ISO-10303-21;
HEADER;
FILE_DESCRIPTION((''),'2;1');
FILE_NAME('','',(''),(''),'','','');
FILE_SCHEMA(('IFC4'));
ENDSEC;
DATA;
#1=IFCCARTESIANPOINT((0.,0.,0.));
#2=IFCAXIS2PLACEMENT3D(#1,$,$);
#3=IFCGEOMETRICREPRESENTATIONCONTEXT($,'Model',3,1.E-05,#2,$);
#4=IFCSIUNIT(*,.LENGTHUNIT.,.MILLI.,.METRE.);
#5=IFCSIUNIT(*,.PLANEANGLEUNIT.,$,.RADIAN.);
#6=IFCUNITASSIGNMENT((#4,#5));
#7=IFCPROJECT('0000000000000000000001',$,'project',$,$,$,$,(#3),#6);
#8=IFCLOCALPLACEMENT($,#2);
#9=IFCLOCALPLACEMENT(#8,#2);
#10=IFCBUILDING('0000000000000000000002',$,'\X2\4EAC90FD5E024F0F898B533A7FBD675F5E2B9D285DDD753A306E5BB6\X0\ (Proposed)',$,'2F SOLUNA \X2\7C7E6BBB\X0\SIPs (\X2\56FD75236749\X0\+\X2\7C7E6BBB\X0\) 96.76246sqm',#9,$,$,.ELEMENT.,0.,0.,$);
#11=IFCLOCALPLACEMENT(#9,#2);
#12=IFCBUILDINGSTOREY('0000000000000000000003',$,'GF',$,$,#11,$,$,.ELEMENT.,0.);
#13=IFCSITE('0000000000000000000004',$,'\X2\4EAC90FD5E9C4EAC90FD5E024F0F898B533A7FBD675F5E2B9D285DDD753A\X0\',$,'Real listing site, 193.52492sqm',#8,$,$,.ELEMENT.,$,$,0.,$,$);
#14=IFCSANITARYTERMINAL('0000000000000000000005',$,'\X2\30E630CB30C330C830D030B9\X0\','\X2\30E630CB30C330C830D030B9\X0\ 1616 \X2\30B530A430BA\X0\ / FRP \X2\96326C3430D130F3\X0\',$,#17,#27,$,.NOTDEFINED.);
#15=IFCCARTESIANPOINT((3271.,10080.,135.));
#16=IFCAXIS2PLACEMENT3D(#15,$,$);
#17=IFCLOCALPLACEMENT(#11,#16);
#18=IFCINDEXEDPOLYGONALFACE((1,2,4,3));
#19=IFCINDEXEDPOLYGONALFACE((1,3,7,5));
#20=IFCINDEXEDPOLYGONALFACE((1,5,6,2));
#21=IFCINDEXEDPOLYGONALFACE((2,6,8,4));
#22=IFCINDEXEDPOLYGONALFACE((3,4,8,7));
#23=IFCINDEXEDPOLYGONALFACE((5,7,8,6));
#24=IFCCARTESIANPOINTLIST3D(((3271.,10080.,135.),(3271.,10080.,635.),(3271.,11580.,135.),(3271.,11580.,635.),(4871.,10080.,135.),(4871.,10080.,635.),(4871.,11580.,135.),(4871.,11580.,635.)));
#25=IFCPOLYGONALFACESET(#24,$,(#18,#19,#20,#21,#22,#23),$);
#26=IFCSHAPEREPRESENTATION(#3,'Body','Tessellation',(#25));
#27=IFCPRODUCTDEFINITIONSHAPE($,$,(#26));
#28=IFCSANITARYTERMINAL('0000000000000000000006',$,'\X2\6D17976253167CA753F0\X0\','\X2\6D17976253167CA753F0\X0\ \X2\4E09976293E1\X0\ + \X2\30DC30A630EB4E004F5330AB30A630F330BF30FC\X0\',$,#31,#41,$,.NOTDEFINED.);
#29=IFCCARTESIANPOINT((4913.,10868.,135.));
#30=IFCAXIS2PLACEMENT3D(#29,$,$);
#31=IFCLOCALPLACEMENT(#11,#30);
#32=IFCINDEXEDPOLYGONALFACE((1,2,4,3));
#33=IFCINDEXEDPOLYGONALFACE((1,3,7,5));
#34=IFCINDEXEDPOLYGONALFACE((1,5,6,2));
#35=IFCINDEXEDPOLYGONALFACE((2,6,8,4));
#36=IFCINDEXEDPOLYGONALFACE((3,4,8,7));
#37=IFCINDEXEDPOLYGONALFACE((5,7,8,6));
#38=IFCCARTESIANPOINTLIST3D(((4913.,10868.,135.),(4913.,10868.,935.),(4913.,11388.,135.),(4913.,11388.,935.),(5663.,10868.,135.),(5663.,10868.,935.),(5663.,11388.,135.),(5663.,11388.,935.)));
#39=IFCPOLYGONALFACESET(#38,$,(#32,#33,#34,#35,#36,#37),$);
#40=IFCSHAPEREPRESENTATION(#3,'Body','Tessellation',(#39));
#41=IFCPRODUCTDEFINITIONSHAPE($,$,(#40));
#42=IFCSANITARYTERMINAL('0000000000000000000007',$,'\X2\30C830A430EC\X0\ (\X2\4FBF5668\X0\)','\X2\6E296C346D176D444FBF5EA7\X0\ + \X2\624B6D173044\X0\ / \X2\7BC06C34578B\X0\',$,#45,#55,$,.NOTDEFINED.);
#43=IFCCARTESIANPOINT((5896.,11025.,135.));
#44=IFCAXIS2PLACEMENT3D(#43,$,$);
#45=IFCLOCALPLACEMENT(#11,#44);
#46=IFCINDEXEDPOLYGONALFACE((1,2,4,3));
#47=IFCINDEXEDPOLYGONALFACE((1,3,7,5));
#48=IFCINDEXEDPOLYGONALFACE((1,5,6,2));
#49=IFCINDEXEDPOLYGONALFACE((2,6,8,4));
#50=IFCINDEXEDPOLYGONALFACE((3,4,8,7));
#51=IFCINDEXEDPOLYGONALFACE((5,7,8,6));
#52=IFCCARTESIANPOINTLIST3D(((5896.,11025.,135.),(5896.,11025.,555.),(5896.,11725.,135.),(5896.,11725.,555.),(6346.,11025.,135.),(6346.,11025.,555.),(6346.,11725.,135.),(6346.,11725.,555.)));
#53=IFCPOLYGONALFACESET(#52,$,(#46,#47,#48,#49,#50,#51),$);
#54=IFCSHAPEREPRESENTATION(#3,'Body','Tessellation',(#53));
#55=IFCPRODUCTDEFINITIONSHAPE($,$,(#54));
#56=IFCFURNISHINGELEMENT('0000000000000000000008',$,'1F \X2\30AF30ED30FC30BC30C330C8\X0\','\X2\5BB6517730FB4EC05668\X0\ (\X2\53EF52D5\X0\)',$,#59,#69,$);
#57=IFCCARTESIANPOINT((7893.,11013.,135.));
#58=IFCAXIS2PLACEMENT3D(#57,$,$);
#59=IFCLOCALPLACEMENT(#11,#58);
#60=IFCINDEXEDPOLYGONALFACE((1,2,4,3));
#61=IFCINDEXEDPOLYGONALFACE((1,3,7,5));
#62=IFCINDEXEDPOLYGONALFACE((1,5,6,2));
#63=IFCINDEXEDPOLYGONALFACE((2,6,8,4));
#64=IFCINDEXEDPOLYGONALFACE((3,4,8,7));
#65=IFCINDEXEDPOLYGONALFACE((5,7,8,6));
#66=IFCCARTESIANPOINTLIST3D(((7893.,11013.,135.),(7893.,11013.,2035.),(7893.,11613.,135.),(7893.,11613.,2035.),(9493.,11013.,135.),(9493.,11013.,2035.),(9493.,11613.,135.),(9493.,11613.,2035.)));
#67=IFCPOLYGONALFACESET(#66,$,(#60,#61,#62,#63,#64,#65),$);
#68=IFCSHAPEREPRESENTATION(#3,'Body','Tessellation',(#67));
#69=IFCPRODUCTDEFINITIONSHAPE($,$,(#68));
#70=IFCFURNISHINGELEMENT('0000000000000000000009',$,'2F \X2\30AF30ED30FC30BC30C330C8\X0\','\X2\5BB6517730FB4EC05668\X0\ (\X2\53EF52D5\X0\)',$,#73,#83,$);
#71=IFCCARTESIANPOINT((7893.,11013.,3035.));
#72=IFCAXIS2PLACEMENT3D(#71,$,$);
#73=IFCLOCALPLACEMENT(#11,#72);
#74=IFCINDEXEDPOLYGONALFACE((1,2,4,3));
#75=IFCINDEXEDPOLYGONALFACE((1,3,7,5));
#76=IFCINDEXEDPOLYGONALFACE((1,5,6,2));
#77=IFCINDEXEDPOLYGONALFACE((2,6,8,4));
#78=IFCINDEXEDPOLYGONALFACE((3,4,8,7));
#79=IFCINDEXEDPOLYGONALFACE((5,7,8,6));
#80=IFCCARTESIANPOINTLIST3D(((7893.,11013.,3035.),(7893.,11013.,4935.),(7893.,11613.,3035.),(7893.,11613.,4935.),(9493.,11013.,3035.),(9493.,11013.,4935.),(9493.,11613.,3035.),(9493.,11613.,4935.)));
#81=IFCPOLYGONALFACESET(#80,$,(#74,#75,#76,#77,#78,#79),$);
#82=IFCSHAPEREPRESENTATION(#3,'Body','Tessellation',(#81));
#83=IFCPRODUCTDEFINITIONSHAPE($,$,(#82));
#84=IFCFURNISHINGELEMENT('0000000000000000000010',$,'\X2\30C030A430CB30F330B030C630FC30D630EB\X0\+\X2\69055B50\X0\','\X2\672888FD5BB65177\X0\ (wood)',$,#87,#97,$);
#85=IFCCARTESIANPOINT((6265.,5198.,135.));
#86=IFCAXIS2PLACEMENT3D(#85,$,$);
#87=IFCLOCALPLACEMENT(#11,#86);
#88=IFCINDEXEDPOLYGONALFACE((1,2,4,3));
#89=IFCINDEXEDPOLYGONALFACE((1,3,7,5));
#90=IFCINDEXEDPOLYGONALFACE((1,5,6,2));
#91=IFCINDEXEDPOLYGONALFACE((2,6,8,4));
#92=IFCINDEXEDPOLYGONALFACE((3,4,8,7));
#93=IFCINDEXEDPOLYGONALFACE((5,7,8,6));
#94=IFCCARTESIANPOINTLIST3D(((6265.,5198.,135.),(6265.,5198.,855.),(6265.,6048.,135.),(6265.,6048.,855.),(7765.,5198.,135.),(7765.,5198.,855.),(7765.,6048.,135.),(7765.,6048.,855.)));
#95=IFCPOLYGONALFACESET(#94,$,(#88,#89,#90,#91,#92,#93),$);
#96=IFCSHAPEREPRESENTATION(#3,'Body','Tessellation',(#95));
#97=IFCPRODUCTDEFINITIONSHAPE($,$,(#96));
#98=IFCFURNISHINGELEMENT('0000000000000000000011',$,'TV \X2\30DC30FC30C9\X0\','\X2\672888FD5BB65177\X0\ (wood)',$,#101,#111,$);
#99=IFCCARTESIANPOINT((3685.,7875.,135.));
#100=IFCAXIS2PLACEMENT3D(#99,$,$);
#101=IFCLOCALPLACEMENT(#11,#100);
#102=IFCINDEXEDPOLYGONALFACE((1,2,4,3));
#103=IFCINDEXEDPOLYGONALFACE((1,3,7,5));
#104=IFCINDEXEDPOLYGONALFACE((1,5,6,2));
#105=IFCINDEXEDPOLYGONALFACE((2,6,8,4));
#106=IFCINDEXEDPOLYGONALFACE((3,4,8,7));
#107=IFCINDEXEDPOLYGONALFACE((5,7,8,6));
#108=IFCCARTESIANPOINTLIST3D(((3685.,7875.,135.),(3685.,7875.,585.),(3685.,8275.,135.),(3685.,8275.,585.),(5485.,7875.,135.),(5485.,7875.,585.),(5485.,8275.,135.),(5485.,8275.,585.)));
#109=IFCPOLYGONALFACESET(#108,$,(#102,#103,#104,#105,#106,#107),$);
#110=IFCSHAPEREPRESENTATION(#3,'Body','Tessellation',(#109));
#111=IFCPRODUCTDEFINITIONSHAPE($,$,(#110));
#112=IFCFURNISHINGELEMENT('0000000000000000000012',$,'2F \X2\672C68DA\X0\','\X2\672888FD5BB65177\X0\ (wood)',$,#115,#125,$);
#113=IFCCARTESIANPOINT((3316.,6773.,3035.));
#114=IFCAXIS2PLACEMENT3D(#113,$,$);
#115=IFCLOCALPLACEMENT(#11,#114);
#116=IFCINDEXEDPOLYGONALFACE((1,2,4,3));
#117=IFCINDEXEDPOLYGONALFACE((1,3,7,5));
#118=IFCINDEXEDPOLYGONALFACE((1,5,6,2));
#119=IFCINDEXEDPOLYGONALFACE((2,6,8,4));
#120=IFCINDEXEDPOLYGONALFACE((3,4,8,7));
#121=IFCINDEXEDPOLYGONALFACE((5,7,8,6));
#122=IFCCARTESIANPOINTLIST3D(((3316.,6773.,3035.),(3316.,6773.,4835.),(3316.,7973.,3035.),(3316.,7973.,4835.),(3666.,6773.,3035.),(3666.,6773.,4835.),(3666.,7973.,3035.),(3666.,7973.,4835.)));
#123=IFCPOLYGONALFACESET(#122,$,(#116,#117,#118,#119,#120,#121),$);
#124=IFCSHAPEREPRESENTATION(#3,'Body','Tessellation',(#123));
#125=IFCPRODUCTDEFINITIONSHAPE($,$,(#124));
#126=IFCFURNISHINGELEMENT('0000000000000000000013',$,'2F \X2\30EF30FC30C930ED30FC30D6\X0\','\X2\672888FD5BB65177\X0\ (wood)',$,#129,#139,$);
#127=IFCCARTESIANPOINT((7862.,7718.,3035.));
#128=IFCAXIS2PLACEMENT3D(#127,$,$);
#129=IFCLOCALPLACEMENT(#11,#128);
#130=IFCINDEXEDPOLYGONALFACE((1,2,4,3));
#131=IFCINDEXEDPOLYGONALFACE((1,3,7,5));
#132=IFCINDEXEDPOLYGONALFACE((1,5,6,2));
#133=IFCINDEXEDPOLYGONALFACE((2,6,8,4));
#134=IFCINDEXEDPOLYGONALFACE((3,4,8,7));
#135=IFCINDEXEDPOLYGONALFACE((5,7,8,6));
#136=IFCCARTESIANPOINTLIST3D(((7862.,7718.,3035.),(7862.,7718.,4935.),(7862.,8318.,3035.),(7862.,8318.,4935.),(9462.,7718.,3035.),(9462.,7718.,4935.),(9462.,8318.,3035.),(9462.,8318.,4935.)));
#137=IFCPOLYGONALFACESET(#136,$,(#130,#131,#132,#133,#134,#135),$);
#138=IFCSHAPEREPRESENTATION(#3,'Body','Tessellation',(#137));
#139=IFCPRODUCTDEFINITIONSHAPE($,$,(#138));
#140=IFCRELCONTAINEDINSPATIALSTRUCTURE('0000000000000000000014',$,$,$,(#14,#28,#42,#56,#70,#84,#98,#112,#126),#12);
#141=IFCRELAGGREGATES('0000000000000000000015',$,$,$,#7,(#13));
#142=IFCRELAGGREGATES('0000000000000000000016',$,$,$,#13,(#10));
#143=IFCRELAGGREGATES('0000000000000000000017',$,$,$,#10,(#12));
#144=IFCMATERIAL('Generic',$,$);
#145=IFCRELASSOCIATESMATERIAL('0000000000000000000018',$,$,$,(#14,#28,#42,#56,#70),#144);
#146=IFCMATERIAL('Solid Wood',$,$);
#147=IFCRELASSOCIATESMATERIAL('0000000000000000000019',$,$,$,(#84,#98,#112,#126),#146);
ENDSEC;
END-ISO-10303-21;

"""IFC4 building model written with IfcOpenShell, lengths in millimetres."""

from ifc_helpers import new_model, si_unit, frame, frame_2d, origin, place, context, project, spatial, rectangle, extrude, material, element, save


model = new_model("IFC4")

# Units and contexts
model_context = context("Model", 3, precision=1e-05, world=origin())
ifc_project = project(units=[si_unit("LENGTHUNIT", "METRE", prefix="MILLI"), si_unit("PLANEANGLEUNIT", "RADIAN")], contexts=[model_context])

# Site, building, storey
site_placement = place(None, origin())
site = spatial("IfcSite", under=ifc_project, at=site_placement, Name="京都府京都市伏見区羽束師鴨川町", ObjectType="Real listing site, 193.52492sqm", CompositionType="ELEMENT", RefElevation=0.0)
building_placement = place(site_placement, origin())
building = spatial("IfcBuilding", under=site, at=building_placement, Name="京都市伏見区羽束師鴨川町の家 (Proposed)", ObjectType="2F SOLUNA 籾殻SIPs (国産杉+籾殻) 96.76246sqm", CompositionType="ELEMENT", ElevationOfRefHeight=0.0, ElevationOfTerrain=0.0)
storey_placement = place(building_placement, origin())
storey = spatial("IfcBuildingStorey", under=building, at=storey_placement, Name="GF", CompositionType="ELEMENT", Elevation=0.0)

# Shared definitions
ifc_material_1 = material(Name="Solid Wood")

# Sanitary terminals
ifc_material_2 = material(Name="Generic")
sanitary_terminal_1_placement = place(storey_placement, frame((3271.0, 10080.0, 135.0)))
element("IfcSanitaryTerminal", 1, at=sanitary_terminal_1_placement, inside=storey, material=ifc_material_2, Name="ユニットバス", Description="ユニットバス 1616 サイズ / FRP 防水パン", PredefinedType="NOTDEFINED", context=model_context, shape_type="SweptSolid", body=[
    extrude(rectangle(XDim=1600.0, YDim=1500.0, at=frame_2d((800.0, 750.0))), frame((3271.0, 10080.0, 135.0)), (0.0, 0.0, 1.0), 500.0),
])
sanitary_terminal_2_placement = place(storey_placement, frame((4913.0, 10868.0, 135.0)))
element("IfcSanitaryTerminal", 2, at=sanitary_terminal_2_placement, inside=storey, material=ifc_material_2, Name="洗面化粧台", Description="洗面化粧台 三面鏡 + ボウル一体カウンター", PredefinedType="NOTDEFINED", context=model_context, shape_type="SweptSolid", body=[
    extrude(rectangle(XDim=750.0, YDim=520.0, at=frame_2d((375.0, 260.0))), frame((4913.0, 10868.0, 135.0)), (0.0, 0.0, 1.0), 800.0),
])
sanitary_terminal_3_placement = place(storey_placement, frame((5896.0, 11025.0, 135.0)))
element("IfcSanitaryTerminal", 3, at=sanitary_terminal_3_placement, inside=storey, material=ifc_material_2, Name="トイレ (便器)", Description="温水洗浄便座 + 手洗い / 節水型", PredefinedType="NOTDEFINED", context=model_context, shape_type="SweptSolid", body=[
    extrude(rectangle(XDim=450.0, YDim=700.0, at=frame_2d((225.0, 350.0))), frame((5896.0, 11025.0, 135.0)), (0.0, 0.0, 1.0), 420.0),
])

# Furnishing elements
furnishing_1_placement = place(storey_placement, frame((7893.0, 11013.0, 135.0)))
element("IfcFurnishingElement", 4, at=furnishing_1_placement, inside=storey, material=ifc_material_2, Name="1F クローゼット", Description="家具・什器 (可動)", context=model_context, shape_type="SweptSolid", body=[
    extrude(rectangle(XDim=1600.0, YDim=600.0, at=frame_2d((800.0, 300.0))), frame((7893.0, 11013.0, 135.0)), (0.0, 0.0, 1.0), 1900.0),
])
furnishing_2_placement = place(storey_placement, frame((7893.0, 11013.0, 3035.0)))
element("IfcFurnishingElement", 5, at=furnishing_2_placement, inside=storey, material=ifc_material_2, Name="2F クローゼット", Description="家具・什器 (可動)", context=model_context, shape_type="SweptSolid", body=[
    extrude(rectangle(XDim=1600.0, YDim=600.0, at=frame_2d((800.0, 300.0))), frame((7893.0, 11013.0, 3035.0)), (0.0, 0.0, 1.0), 1900.0),
])
furnishing_3_placement = place(storey_placement, frame((6265.0, 5198.0, 135.0)))
element("IfcFurnishingElement", 6, at=furnishing_3_placement, inside=storey, material=ifc_material_1, Name="ダイニングテーブル+椅子", Description="木製家具 (wood)", context=model_context, shape_type="SweptSolid", body=[
    extrude(rectangle(XDim=1500.0, YDim=850.0, at=frame_2d((750.0, 425.0))), frame((6265.0, 5198.0, 135.0)), (0.0, 0.0, 1.0), 720.0),
])
furnishing_4_placement = place(storey_placement, frame((3685.0, 7875.0, 135.0)))
element("IfcFurnishingElement", 7, at=furnishing_4_placement, inside=storey, material=ifc_material_1, Name="TV ボード", Description="木製家具 (wood)", context=model_context, shape_type="SweptSolid", body=[
    extrude(rectangle(XDim=1800.0, YDim=400.0, at=frame_2d((900.0, 200.0))), frame((3685.0, 7875.0, 135.0)), (0.0, 0.0, 1.0), 450.0),
])
furnishing_5_placement = place(storey_placement, frame((3316.0, 6773.0, 3035.0)))
element("IfcFurnishingElement", 8, at=furnishing_5_placement, inside=storey, material=ifc_material_1, Name="2F 本棚", Description="木製家具 (wood)", context=model_context, shape_type="SweptSolid", body=[
    extrude(rectangle(XDim=350.0, YDim=1200.0, at=frame_2d((175.0, 600.0))), frame((3316.0, 6773.0, 3035.0)), (0.0, 0.0, 1.0), 1800.0),
])
furnishing_6_placement = place(storey_placement, frame((7862.0, 7718.0, 3035.0)))
element("IfcFurnishingElement", 9, at=furnishing_6_placement, inside=storey, material=ifc_material_1, Name="2F ワードローブ", Description="木製家具 (wood)", context=model_context, shape_type="SweptSolid", body=[
    extrude(rectangle(XDim=1600.0, YDim=600.0, at=frame_2d((800.0, 300.0))), frame((7862.0, 7718.0, 3035.0)), (0.0, 0.0, 1.0), 1900.0),
])

save(model, "model.ifc")
